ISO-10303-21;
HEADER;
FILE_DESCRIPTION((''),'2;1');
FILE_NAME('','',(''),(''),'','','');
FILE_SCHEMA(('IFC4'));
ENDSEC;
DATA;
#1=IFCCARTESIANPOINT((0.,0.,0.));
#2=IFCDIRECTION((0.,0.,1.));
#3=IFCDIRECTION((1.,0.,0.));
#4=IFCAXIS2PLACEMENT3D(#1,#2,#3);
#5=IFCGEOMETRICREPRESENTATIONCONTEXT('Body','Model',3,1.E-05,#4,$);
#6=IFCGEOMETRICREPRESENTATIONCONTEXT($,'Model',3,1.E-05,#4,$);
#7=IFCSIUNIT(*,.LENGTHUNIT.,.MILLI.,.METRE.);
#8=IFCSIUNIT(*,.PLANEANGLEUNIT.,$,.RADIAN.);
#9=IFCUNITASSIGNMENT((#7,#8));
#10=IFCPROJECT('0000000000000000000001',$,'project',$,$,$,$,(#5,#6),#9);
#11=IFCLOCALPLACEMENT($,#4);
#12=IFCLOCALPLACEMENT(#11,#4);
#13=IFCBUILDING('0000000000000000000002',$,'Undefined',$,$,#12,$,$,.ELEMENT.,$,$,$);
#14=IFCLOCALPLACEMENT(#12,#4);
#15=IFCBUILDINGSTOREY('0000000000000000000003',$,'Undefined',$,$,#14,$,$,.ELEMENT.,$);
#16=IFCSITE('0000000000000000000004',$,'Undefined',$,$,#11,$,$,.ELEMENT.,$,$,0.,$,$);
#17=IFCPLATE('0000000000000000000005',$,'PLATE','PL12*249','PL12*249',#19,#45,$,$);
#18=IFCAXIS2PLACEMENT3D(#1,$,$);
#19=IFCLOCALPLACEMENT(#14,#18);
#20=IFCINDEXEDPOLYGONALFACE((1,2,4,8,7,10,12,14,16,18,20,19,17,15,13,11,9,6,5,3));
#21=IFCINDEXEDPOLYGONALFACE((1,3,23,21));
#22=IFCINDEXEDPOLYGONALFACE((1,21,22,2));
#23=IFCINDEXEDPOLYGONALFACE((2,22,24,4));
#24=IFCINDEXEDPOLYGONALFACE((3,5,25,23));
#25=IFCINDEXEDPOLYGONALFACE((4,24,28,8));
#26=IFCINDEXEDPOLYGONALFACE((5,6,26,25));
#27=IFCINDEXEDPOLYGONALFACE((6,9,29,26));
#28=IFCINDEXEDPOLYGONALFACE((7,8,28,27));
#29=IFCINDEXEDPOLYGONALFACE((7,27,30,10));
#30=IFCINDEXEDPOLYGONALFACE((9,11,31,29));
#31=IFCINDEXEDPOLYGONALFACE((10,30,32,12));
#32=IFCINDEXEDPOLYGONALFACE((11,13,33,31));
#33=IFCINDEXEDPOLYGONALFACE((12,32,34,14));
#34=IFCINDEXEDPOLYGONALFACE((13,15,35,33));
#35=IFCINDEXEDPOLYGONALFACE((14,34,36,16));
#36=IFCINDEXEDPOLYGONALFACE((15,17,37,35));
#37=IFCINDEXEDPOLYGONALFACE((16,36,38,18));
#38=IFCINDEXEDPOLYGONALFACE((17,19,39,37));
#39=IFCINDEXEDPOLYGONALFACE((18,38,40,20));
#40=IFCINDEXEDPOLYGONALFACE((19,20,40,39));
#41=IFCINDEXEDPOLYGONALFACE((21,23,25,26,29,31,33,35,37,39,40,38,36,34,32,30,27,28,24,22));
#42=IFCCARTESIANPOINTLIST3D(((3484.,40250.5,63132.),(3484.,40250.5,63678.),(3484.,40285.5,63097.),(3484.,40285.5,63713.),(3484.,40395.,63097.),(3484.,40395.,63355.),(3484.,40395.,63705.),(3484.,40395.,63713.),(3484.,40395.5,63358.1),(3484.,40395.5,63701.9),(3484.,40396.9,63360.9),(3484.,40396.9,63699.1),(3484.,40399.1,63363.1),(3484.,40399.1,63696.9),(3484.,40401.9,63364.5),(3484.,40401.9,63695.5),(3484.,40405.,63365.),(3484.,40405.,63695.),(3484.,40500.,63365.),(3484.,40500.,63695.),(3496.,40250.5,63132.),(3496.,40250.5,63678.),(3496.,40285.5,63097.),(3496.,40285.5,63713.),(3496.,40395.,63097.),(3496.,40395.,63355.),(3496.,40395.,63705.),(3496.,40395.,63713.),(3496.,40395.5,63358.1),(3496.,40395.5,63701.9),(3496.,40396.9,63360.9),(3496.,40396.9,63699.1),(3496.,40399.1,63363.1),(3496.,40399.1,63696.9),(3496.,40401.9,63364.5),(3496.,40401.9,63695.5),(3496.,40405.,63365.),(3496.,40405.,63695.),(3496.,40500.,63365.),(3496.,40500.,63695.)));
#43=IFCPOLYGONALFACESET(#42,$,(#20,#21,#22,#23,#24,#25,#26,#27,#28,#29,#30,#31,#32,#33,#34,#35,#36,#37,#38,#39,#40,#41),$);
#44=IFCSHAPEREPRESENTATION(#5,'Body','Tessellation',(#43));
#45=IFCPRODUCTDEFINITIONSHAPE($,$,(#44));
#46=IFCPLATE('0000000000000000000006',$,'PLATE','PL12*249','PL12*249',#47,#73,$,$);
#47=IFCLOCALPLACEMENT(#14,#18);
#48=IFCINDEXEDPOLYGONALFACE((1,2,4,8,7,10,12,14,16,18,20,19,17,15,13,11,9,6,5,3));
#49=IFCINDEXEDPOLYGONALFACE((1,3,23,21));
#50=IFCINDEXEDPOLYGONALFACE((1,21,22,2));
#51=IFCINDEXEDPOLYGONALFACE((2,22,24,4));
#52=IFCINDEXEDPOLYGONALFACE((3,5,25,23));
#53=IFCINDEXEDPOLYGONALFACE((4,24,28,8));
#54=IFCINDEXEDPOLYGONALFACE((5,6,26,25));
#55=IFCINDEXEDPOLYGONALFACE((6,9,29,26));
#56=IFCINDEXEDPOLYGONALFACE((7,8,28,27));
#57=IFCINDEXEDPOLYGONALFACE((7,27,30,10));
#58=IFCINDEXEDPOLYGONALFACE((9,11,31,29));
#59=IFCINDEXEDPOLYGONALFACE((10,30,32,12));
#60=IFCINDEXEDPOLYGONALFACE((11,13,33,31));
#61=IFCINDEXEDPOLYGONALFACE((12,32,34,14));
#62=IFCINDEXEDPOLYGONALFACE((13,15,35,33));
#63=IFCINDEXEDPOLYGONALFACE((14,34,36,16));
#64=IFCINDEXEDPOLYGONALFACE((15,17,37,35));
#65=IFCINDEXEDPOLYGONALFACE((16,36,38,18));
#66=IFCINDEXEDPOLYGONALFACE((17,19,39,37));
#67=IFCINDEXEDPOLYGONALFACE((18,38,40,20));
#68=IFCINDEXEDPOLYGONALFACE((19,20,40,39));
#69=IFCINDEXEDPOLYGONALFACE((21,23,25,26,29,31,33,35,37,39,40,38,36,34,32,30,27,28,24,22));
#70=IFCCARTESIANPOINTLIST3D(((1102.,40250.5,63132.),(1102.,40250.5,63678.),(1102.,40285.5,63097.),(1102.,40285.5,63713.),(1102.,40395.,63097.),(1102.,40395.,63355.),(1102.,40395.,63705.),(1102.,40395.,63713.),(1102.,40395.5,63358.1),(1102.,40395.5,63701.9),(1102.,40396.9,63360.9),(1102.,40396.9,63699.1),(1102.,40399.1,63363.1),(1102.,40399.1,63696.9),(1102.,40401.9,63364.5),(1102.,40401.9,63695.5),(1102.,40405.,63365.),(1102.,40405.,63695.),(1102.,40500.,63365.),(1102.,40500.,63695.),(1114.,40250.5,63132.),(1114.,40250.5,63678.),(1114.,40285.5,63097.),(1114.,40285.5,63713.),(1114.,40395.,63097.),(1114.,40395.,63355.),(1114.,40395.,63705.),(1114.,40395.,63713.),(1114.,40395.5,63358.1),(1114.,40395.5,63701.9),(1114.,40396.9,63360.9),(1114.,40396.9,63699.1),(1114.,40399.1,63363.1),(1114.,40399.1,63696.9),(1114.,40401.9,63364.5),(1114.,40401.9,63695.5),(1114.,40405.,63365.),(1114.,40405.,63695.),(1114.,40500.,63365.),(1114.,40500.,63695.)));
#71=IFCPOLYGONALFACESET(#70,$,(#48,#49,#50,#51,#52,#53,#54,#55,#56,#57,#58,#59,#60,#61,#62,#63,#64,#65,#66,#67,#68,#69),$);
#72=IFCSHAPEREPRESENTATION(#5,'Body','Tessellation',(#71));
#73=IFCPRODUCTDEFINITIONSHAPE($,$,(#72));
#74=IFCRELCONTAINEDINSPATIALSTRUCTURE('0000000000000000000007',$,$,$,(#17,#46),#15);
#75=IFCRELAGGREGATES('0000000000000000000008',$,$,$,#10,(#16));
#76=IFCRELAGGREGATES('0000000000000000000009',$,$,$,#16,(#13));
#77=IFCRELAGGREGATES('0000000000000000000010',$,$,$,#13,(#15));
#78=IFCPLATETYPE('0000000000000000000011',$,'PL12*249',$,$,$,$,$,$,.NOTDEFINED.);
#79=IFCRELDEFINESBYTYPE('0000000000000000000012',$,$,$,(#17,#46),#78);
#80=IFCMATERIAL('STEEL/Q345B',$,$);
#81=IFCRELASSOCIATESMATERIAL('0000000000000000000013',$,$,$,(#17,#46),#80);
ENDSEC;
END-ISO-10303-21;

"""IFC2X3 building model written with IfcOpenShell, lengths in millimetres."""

from ifc_helpers import new_model, si_unit, frame, origin_with_axes, place, context, project, spatial, polyline, outline, extrude, material, type_object, element, save


model = new_model("IFC2X3")

# Units and contexts
model_context_1 = context("Model", 3, precision=1e-05, world=origin_with_axes(), identifier="Body")
model_context_2 = context("Model", 3, precision=1e-05, world=origin_with_axes())
ifc_project = project(units=[si_unit("LENGTHUNIT", "METRE", prefix="MILLI"), si_unit("PLANEANGLEUNIT", "RADIAN")], contexts=[model_context_1, model_context_2])

# Site, building, storey
site_placement = place(None, origin_with_axes())
site = spatial("IfcSite", under=ifc_project, at=site_placement, Name="Undefined", CompositionType="ELEMENT", RefElevation=0.0)
building_placement = place(site_placement, origin_with_axes())
building = spatial("IfcBuilding", under=site, at=building_placement, Name="Undefined", CompositionType="ELEMENT")
storey_placement = place(building_placement, origin_with_axes())
storey = spatial("IfcBuildingStorey", under=building, at=storey_placement, Name="Undefined", CompositionType="ELEMENT")

# Shared definitions
ifc_material_1 = material(Name="STEEL/Q345B")

# Plates
plate_type_1 = type_object("IfcPlateType", Name="PL12*249", PredefinedType="NOTDEFINED")
for number, where, z_axis, x_axis, name in (
    (1, (3490.0, 40250.5, 63132.0), (1.0, 0.0, 0.0), (0.0, 0.707107, -0.707107), "PLATE"),
    (2, (1108.0, 40250.5, 63132.0), (1.0, 0.0, 0.0), (0.0, 0.707107, -0.707107), "PLATE"),
):
    element("IfcPlate", number, at=place(storey_placement, frame(where, z_axis=z_axis, x_axis=x_axis)), inside=storey, type_object=plate_type_1, material=ifc_material_1, Name=name, Description="PL12*249", ObjectType="PL12*249", context=model_context_1, shape_type="SweptSolid", body=[
        extrude(outline(polyline([(0.0, 0.0), (49.5, 0.0), (126.9, 77.4), (-55.5, 259.9), (-57.3, 262.4), (-58.3, 265.4), (-58.3, 268.5), (-57.3, 271.5), (-55.5, 274.0), (11.7, 341.2), (-221.7, 574.5), (-288.9, 507.3), (-291.4, 505.5), (-294.4, 504.5), (-297.5, 504.5), (-300.5, 505.5), (-303.0, 507.3), (-308.7, 513.0), (-386.1, 435.6), (-386.1, 386.1), (0.0, 0.0)])), frame((0.0, 0.0, -6.0), z_axis=(0.0, 0.0, 1.0), x_axis=(1.0, 0.0, 0.0)), (0.0, 0.0, 1.0), 12.0),
    ])

save(model, "model.ifc")
